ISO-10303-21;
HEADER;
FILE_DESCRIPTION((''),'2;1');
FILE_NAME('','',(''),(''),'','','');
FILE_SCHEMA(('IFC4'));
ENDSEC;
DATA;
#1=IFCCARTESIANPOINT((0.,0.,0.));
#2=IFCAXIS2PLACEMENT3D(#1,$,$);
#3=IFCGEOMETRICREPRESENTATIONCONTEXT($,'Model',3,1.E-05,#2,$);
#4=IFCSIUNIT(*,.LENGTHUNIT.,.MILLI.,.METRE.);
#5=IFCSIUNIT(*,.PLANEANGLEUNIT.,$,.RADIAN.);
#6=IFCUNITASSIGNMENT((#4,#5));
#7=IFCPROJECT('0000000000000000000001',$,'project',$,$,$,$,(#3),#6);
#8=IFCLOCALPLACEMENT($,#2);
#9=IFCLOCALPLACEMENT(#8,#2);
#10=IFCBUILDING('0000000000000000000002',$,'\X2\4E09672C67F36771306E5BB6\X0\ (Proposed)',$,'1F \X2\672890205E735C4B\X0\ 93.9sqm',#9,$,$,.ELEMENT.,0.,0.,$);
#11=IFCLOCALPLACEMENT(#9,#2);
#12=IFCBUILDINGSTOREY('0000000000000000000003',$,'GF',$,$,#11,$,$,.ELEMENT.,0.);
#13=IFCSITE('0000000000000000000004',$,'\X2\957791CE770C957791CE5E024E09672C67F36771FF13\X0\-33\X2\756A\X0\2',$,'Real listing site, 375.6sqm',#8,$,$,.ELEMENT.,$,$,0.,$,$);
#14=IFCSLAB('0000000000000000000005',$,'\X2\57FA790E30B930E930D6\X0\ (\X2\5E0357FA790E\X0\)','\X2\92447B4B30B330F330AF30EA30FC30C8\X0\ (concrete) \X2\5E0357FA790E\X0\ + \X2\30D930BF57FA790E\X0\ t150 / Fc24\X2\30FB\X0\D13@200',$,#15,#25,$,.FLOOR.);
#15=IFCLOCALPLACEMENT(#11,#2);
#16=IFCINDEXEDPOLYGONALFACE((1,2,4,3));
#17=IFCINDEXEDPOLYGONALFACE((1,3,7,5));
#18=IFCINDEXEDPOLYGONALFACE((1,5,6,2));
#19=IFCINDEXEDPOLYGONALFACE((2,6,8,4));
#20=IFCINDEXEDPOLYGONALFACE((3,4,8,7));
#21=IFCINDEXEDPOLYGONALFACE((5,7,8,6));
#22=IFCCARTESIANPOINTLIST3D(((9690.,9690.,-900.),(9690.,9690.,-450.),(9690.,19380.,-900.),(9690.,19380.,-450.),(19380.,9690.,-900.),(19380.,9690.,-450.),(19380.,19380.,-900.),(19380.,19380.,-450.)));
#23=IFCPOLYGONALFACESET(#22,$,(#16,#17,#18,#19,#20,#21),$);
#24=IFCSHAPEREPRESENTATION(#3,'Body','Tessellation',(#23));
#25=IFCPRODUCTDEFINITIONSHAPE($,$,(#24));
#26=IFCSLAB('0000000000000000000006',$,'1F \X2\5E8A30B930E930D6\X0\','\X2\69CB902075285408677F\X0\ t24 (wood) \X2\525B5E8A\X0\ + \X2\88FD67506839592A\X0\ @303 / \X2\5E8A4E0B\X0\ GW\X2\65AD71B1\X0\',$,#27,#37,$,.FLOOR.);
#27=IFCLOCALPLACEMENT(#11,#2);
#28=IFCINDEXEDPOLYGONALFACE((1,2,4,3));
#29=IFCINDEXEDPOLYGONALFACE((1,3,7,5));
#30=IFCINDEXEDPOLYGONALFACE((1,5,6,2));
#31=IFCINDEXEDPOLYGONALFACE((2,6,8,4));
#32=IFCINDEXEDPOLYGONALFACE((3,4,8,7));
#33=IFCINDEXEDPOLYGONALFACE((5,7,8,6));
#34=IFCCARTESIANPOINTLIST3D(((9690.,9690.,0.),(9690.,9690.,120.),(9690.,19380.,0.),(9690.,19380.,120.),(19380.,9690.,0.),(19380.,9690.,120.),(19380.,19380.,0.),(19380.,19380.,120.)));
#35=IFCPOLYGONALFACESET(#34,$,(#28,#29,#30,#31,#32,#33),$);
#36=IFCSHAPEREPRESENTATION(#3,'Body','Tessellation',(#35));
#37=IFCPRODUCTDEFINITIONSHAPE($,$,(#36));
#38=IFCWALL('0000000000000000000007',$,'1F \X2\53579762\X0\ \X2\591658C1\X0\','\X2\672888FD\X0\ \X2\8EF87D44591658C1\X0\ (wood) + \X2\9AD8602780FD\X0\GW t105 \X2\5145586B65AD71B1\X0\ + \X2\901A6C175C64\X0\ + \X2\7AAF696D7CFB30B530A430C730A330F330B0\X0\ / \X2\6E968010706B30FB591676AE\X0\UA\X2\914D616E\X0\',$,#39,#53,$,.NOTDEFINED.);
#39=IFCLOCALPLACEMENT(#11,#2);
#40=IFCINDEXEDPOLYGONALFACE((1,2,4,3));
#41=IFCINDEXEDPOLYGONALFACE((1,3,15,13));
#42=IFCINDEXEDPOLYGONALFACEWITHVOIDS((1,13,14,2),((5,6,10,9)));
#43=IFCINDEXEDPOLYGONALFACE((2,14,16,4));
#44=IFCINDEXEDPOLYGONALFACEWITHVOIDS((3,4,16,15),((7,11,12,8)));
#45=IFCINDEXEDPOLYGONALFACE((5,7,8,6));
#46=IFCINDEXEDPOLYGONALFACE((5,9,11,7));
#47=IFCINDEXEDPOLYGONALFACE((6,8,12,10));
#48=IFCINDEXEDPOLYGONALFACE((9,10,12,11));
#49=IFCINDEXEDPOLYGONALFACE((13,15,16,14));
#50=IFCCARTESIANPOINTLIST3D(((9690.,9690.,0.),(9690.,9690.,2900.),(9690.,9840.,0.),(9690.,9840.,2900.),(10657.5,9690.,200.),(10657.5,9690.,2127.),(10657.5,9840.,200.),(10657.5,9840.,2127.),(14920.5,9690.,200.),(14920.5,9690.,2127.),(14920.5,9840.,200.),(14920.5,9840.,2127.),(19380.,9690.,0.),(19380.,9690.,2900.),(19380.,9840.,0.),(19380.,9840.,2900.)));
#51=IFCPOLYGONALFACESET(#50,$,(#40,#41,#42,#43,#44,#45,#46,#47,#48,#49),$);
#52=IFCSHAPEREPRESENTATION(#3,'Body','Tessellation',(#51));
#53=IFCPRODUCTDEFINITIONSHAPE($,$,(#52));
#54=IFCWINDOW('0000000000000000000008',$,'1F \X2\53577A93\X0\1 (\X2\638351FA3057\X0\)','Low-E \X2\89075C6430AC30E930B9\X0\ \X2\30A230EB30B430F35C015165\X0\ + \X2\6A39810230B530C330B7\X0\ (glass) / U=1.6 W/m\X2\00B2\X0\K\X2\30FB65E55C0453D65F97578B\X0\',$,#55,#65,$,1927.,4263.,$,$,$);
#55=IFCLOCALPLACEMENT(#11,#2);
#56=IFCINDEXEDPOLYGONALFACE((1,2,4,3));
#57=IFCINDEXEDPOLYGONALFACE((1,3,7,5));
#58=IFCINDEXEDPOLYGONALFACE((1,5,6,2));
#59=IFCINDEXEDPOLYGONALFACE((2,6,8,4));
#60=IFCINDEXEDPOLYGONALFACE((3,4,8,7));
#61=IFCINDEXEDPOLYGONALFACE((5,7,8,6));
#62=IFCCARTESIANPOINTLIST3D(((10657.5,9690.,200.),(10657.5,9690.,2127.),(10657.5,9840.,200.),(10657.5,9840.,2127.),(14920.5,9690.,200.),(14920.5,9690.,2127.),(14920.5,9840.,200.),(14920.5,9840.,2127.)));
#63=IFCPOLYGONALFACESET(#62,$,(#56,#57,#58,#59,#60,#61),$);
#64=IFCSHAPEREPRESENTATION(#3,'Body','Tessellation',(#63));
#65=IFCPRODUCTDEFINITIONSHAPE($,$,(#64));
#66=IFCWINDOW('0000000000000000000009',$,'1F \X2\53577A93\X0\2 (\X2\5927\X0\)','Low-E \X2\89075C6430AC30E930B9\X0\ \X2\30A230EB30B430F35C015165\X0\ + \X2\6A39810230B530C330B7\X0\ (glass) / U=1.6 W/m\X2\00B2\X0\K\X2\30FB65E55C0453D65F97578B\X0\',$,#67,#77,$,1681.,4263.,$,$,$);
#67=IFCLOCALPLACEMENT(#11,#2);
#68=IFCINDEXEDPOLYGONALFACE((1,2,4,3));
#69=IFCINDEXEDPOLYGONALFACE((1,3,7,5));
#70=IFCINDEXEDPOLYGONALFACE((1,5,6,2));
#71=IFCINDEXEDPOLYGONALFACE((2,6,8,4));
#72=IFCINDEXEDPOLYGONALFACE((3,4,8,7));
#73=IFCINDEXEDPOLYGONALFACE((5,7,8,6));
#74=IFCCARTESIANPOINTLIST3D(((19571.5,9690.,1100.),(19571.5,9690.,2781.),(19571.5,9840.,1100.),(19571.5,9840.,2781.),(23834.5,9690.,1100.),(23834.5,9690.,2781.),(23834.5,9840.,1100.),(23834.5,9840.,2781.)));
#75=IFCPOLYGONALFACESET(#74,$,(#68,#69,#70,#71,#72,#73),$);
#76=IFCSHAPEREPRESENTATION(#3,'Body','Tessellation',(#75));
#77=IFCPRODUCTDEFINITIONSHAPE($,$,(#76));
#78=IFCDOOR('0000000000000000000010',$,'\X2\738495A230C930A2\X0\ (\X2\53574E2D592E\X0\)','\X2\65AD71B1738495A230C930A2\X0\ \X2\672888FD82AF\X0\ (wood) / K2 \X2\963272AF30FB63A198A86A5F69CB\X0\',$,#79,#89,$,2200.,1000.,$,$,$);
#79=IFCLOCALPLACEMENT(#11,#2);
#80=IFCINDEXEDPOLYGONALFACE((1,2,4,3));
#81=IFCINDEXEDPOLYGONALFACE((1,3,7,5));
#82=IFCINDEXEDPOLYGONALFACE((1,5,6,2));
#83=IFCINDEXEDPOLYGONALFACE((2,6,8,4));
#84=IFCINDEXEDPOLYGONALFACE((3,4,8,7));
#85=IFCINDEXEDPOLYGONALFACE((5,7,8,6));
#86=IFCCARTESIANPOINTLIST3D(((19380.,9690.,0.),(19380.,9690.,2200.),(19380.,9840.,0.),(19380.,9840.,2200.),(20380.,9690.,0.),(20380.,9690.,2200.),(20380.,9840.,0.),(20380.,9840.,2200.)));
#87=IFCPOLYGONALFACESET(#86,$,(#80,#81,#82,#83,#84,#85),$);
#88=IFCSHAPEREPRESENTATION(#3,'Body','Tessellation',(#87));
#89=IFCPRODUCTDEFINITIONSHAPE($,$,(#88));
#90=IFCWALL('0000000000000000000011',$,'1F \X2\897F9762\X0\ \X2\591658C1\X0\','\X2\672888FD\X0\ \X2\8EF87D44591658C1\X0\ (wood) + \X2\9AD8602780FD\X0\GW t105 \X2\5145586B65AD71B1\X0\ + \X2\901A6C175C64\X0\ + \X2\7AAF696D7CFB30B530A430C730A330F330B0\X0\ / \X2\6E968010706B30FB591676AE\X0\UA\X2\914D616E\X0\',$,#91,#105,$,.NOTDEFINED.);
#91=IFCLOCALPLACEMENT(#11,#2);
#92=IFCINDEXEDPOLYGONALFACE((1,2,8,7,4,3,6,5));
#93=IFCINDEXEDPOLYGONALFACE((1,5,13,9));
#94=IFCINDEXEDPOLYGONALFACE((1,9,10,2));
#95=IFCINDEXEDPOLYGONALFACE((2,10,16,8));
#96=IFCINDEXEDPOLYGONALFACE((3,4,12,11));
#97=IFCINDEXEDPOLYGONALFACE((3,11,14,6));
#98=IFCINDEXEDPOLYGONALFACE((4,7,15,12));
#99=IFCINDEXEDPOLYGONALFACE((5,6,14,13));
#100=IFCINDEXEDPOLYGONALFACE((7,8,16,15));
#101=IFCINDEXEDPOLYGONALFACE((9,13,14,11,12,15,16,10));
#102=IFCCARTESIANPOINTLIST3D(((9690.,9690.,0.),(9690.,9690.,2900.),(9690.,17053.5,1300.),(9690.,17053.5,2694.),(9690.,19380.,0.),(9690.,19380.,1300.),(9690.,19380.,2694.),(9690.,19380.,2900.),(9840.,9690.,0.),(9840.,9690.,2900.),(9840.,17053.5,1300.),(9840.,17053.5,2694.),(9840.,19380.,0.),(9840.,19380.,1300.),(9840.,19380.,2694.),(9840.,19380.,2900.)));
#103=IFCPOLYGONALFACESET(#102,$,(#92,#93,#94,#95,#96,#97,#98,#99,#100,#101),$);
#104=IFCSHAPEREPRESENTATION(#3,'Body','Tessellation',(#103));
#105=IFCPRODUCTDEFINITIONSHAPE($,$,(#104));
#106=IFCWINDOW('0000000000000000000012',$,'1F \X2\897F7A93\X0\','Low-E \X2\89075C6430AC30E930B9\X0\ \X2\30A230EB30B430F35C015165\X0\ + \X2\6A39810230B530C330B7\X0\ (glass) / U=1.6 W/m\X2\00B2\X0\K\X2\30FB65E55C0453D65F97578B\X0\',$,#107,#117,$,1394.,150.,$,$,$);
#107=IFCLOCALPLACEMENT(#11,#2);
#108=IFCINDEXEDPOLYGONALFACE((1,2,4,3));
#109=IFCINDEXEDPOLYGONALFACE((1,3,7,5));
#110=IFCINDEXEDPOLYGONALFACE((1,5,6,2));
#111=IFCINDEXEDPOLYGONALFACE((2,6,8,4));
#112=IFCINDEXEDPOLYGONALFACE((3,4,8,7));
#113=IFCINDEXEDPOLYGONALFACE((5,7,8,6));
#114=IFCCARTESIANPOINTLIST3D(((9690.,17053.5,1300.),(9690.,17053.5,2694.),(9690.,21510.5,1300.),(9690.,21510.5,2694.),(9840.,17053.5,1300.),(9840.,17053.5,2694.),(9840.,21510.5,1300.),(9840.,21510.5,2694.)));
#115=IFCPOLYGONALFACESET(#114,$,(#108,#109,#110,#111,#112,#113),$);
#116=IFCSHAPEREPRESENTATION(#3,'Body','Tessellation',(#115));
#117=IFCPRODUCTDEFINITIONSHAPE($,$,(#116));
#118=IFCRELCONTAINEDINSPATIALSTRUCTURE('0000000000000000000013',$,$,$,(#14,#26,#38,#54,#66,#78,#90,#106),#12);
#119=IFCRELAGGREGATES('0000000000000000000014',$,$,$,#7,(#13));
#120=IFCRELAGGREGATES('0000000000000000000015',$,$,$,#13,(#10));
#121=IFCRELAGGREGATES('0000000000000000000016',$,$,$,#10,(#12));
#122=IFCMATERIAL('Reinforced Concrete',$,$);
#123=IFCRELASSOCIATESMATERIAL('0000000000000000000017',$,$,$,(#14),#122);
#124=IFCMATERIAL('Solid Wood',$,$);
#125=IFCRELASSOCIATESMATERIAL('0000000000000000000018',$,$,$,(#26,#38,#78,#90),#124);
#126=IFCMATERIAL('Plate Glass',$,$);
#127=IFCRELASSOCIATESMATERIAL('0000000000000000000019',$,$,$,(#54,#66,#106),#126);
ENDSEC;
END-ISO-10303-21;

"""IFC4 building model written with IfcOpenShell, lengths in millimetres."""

from ifc_helpers import new_model, si_unit, frame, frame_2d, origin, place, context, project, spatial, rectangle, extrude, material, element, fill, save


model = new_model("IFC4")

# Units and contexts
model_context = context("Model", 3, precision=1e-05, world=origin())
ifc_project = project(units=[si_unit("LENGTHUNIT", "METRE", prefix="MILLI"), si_unit("PLANEANGLEUNIT", "RADIAN")], contexts=[model_context])

# Site, building, storey
site_placement = place(None, origin())
site = spatial("IfcSite", under=ifc_project, at=site_placement, Name="長野県長野市三本柳東３-33番2", ObjectType="Real listing site, 375.6sqm", CompositionType="ELEMENT", RefElevation=0.0)
building_placement = place(site_placement, origin())
building = spatial("IfcBuilding", under=site, at=building_placement, Name="三本柳東の家 (Proposed)", ObjectType="1F 木造平屋 93.9sqm", CompositionType="ELEMENT", ElevationOfRefHeight=0.0, ElevationOfTerrain=0.0)
storey_placement = place(building_placement, origin())
storey = spatial("IfcBuildingStorey", under=building, at=storey_placement, Name="GF", CompositionType="ELEMENT", Elevation=0.0)

# Slabs
ifc_material_1 = material(Name="Reinforced Concrete")
slab_1_placement = place(storey_placement, frame((4845.0, 4845.0, -450.0)))
element("IfcSlab", 1, at=slab_1_placement, inside=storey, material=ifc_material_1, Name="基礎スラブ (布基礎)", Description="鉄筋コンクリート (concrete) 布基礎 + ベタ基礎 t150 / Fc24・D13@200", PredefinedType="FLOOR", context=model_context, shape_type="SweptSolid", body=[
    extrude(rectangle(XDim=9690.0, YDim=9690.0, at=frame_2d((4845.0, 4845.0))), frame((4845.0, 4845.0, -450.0)), (0.0, 0.0, 1.0), 450.0),
])
ifc_material_2 = material(Name="Solid Wood")
slab_2_placement = place(storey_placement, frame((4845.0, 4845.0, 0.0)))
element("IfcSlab", 2, at=slab_2_placement, inside=storey, material=ifc_material_2, Name="1F 床スラブ", Description="構造用合板 t24 (wood) 剛床 + 製材根太 @303 / 床下 GW断熱", PredefinedType="FLOOR", context=model_context, shape_type="SweptSolid", body=[
    extrude(rectangle(XDim=9690.0, YDim=9690.0, at=frame_2d((4845.0, 4845.0))), frame((4845.0, 4845.0, 0.0)), (0.0, 0.0, 1.0), 120.0),
])

# Wall, openings, windows, door
wall_1_placement = place(storey_placement, frame((4845.0, 4845.0, 0.0)))
wall_1 = element("IfcWall", 3, at=wall_1_placement, inside=storey, material=ifc_material_2, Name="1F 南面 外壁", Description="木製 軸組外壁 (wood) + 高性能GW t105 充填断熱 + 通気層 + 窯業系サイディング / 準耐火・外皮UA配慮", PredefinedType="NOTDEFINED", context=model_context, shape_type="SweptSolid", body=[
    extrude(rectangle(XDim=9690.0, YDim=150.0, at=frame_2d((4845.0, 75.0))), frame((4845.0, 4845.0, 0.0)), (0.0, 0.0, 1.0), 2900.0),
])
opening_1_placement = place(storey_placement, frame((5329.0, 4845.0, 100.0)))
opening_1 = element("IfcOpeningElement", 4, at=opening_1_placement, cuts=wall_1, PredefinedType="NOTDEFINED", context=model_context, shape_type="SweptSolid", body=[
    extrude(rectangle(XDim=4263.0, YDim=150.0, at=frame_2d((2131.0, 75.0))), frame((5329.0, 4845.0, 100.0)), (0.0, 0.0, 1.0), 1927.0),
])
opening_2_placement = place(storey_placement, frame((9786.0, 4845.0, 550.0)))
opening_2 = element("IfcOpeningElement", 5, at=opening_2_placement, cuts=wall_1, PredefinedType="NOTDEFINED", context=model_context, shape_type="SweptSolid", body=[
    extrude(rectangle(XDim=4263.0, YDim=150.0, at=frame_2d((2131.0, 75.0))), frame((9786.0, 4845.0, 550.0)), (0.0, 0.0, 1.0), 1681.0),
])
opening_3_placement = place(storey_placement, frame((9690.0, 4845.0, 0.0)))
opening_3 = element("IfcOpeningElement", 6, at=opening_3_placement, cuts=wall_1, PredefinedType="NOTDEFINED", context=model_context, shape_type="SweptSolid", body=[
    extrude(rectangle(XDim=1000.0, YDim=150.0, at=frame_2d((500.0, 75.0))), frame((9690.0, 4845.0, 0.0)), (0.0, 0.0, 1.0), 2200.0),
])
ifc_material_3 = material(Name="Plate Glass")
window_1_placement = place(storey_placement, frame((5329.0, 4845.0, 100.0)))
window_1 = element("IfcWindow", 7, at=window_1_placement, inside=storey, material=ifc_material_3, Name="1F 南窓1 (掃出し)", Description="Low-E 複層ガラス アルゴン封入 + 樹脂サッシ (glass) / U=1.6 W/m²K・日射取得型", OverallHeight=1927.0, OverallWidth=4263.0, context=model_context, shape_type="SweptSolid", body=[
    extrude(rectangle(XDim=4263.0, YDim=150.0, at=frame_2d((2131.0, 75.0))), frame((5329.0, 4845.0, 100.0)), (0.0, 0.0, 1.0), 1927.0),
])
fill(opening_1, window_1)
window_2_placement = place(storey_placement, frame((9786.0, 4845.0, 550.0)))
window_2 = element("IfcWindow", 8, at=window_2_placement, inside=storey, material=ifc_material_3, Name="1F 南窓2 (大)", Description="Low-E 複層ガラス アルゴン封入 + 樹脂サッシ (glass) / U=1.6 W/m²K・日射取得型", OverallHeight=1681.0, OverallWidth=4263.0, context=model_context, shape_type="SweptSolid", body=[
    extrude(rectangle(XDim=4263.0, YDim=150.0, at=frame_2d((2131.0, 75.0))), frame((9786.0, 4845.0, 550.0)), (0.0, 0.0, 1.0), 1681.0),
])
fill(opening_2, window_2)
door_placement = place(storey_placement, frame((9690.0, 4845.0, 0.0)))
door = element("IfcDoor", 9, at=door_placement, inside=storey, material=ifc_material_2, Name="玄関ドア (南中央)", Description="断熱玄関ドア 木製芯 (wood) / K2 防犯・採風機構", OverallHeight=2200.0, OverallWidth=1000.0, context=model_context, shape_type="SweptSolid", body=[
    extrude(rectangle(XDim=1000.0, YDim=150.0, at=frame_2d((500.0, 75.0))), frame((9690.0, 4845.0, 0.0)), (0.0, 0.0, 1.0), 2200.0),
])
fill(opening_3, door)

# Wall, opening, window
wall_2_placement = place(storey_placement, frame((4845.0, 4845.0, 0.0)))
wall_2 = element("IfcWall", 10, at=wall_2_placement, inside=storey, material=ifc_material_2, Name="1F 西面 外壁", Description="木製 軸組外壁 (wood) + 高性能GW t105 充填断熱 + 通気層 + 窯業系サイディング / 準耐火・外皮UA配慮", PredefinedType="NOTDEFINED", context=model_context, shape_type="SweptSolid", body=[
    extrude(rectangle(XDim=150.0, YDim=9690.0, at=frame_2d((75.0, 4845.0))), frame((4845.0, 4845.0, 0.0)), (0.0, 0.0, 1.0), 2900.0),
])
opening_4_placement = place(storey_placement, frame((4845.0, 8527.0, 650.0)))
opening_4 = element("IfcOpeningElement", 11, at=opening_4_placement, cuts=wall_2, PredefinedType="NOTDEFINED", context=model_context, shape_type="SweptSolid", body=[
    extrude(rectangle(XDim=150.0, YDim=4457.0, at=frame_2d((75.0, 2228.0))), frame((4845.0, 8527.0, 650.0)), (0.0, 0.0, 1.0), 1394.0),
])
window_3_placement = place(storey_placement, frame((4845.0, 8527.0, 650.0)))
window_3 = element("IfcWindow", 12, at=window_3_placement, inside=storey, material=ifc_material_3, Name="1F 西窓", Description="Low-E 複層ガラス アルゴン封入 + 樹脂サッシ (glass) / U=1.6 W/m²K・日射取得型", OverallHeight=1394.0, OverallWidth=150.0, context=model_context, shape_type="SweptSolid", body=[
    extrude(rectangle(XDim=150.0, YDim=4457.0, at=frame_2d((75.0, 2228.0))), frame((4845.0, 8527.0, 650.0)), (0.0, 0.0, 1.0), 1394.0),
])
fill(opening_4, window_3)

save(model, "model.ifc")
